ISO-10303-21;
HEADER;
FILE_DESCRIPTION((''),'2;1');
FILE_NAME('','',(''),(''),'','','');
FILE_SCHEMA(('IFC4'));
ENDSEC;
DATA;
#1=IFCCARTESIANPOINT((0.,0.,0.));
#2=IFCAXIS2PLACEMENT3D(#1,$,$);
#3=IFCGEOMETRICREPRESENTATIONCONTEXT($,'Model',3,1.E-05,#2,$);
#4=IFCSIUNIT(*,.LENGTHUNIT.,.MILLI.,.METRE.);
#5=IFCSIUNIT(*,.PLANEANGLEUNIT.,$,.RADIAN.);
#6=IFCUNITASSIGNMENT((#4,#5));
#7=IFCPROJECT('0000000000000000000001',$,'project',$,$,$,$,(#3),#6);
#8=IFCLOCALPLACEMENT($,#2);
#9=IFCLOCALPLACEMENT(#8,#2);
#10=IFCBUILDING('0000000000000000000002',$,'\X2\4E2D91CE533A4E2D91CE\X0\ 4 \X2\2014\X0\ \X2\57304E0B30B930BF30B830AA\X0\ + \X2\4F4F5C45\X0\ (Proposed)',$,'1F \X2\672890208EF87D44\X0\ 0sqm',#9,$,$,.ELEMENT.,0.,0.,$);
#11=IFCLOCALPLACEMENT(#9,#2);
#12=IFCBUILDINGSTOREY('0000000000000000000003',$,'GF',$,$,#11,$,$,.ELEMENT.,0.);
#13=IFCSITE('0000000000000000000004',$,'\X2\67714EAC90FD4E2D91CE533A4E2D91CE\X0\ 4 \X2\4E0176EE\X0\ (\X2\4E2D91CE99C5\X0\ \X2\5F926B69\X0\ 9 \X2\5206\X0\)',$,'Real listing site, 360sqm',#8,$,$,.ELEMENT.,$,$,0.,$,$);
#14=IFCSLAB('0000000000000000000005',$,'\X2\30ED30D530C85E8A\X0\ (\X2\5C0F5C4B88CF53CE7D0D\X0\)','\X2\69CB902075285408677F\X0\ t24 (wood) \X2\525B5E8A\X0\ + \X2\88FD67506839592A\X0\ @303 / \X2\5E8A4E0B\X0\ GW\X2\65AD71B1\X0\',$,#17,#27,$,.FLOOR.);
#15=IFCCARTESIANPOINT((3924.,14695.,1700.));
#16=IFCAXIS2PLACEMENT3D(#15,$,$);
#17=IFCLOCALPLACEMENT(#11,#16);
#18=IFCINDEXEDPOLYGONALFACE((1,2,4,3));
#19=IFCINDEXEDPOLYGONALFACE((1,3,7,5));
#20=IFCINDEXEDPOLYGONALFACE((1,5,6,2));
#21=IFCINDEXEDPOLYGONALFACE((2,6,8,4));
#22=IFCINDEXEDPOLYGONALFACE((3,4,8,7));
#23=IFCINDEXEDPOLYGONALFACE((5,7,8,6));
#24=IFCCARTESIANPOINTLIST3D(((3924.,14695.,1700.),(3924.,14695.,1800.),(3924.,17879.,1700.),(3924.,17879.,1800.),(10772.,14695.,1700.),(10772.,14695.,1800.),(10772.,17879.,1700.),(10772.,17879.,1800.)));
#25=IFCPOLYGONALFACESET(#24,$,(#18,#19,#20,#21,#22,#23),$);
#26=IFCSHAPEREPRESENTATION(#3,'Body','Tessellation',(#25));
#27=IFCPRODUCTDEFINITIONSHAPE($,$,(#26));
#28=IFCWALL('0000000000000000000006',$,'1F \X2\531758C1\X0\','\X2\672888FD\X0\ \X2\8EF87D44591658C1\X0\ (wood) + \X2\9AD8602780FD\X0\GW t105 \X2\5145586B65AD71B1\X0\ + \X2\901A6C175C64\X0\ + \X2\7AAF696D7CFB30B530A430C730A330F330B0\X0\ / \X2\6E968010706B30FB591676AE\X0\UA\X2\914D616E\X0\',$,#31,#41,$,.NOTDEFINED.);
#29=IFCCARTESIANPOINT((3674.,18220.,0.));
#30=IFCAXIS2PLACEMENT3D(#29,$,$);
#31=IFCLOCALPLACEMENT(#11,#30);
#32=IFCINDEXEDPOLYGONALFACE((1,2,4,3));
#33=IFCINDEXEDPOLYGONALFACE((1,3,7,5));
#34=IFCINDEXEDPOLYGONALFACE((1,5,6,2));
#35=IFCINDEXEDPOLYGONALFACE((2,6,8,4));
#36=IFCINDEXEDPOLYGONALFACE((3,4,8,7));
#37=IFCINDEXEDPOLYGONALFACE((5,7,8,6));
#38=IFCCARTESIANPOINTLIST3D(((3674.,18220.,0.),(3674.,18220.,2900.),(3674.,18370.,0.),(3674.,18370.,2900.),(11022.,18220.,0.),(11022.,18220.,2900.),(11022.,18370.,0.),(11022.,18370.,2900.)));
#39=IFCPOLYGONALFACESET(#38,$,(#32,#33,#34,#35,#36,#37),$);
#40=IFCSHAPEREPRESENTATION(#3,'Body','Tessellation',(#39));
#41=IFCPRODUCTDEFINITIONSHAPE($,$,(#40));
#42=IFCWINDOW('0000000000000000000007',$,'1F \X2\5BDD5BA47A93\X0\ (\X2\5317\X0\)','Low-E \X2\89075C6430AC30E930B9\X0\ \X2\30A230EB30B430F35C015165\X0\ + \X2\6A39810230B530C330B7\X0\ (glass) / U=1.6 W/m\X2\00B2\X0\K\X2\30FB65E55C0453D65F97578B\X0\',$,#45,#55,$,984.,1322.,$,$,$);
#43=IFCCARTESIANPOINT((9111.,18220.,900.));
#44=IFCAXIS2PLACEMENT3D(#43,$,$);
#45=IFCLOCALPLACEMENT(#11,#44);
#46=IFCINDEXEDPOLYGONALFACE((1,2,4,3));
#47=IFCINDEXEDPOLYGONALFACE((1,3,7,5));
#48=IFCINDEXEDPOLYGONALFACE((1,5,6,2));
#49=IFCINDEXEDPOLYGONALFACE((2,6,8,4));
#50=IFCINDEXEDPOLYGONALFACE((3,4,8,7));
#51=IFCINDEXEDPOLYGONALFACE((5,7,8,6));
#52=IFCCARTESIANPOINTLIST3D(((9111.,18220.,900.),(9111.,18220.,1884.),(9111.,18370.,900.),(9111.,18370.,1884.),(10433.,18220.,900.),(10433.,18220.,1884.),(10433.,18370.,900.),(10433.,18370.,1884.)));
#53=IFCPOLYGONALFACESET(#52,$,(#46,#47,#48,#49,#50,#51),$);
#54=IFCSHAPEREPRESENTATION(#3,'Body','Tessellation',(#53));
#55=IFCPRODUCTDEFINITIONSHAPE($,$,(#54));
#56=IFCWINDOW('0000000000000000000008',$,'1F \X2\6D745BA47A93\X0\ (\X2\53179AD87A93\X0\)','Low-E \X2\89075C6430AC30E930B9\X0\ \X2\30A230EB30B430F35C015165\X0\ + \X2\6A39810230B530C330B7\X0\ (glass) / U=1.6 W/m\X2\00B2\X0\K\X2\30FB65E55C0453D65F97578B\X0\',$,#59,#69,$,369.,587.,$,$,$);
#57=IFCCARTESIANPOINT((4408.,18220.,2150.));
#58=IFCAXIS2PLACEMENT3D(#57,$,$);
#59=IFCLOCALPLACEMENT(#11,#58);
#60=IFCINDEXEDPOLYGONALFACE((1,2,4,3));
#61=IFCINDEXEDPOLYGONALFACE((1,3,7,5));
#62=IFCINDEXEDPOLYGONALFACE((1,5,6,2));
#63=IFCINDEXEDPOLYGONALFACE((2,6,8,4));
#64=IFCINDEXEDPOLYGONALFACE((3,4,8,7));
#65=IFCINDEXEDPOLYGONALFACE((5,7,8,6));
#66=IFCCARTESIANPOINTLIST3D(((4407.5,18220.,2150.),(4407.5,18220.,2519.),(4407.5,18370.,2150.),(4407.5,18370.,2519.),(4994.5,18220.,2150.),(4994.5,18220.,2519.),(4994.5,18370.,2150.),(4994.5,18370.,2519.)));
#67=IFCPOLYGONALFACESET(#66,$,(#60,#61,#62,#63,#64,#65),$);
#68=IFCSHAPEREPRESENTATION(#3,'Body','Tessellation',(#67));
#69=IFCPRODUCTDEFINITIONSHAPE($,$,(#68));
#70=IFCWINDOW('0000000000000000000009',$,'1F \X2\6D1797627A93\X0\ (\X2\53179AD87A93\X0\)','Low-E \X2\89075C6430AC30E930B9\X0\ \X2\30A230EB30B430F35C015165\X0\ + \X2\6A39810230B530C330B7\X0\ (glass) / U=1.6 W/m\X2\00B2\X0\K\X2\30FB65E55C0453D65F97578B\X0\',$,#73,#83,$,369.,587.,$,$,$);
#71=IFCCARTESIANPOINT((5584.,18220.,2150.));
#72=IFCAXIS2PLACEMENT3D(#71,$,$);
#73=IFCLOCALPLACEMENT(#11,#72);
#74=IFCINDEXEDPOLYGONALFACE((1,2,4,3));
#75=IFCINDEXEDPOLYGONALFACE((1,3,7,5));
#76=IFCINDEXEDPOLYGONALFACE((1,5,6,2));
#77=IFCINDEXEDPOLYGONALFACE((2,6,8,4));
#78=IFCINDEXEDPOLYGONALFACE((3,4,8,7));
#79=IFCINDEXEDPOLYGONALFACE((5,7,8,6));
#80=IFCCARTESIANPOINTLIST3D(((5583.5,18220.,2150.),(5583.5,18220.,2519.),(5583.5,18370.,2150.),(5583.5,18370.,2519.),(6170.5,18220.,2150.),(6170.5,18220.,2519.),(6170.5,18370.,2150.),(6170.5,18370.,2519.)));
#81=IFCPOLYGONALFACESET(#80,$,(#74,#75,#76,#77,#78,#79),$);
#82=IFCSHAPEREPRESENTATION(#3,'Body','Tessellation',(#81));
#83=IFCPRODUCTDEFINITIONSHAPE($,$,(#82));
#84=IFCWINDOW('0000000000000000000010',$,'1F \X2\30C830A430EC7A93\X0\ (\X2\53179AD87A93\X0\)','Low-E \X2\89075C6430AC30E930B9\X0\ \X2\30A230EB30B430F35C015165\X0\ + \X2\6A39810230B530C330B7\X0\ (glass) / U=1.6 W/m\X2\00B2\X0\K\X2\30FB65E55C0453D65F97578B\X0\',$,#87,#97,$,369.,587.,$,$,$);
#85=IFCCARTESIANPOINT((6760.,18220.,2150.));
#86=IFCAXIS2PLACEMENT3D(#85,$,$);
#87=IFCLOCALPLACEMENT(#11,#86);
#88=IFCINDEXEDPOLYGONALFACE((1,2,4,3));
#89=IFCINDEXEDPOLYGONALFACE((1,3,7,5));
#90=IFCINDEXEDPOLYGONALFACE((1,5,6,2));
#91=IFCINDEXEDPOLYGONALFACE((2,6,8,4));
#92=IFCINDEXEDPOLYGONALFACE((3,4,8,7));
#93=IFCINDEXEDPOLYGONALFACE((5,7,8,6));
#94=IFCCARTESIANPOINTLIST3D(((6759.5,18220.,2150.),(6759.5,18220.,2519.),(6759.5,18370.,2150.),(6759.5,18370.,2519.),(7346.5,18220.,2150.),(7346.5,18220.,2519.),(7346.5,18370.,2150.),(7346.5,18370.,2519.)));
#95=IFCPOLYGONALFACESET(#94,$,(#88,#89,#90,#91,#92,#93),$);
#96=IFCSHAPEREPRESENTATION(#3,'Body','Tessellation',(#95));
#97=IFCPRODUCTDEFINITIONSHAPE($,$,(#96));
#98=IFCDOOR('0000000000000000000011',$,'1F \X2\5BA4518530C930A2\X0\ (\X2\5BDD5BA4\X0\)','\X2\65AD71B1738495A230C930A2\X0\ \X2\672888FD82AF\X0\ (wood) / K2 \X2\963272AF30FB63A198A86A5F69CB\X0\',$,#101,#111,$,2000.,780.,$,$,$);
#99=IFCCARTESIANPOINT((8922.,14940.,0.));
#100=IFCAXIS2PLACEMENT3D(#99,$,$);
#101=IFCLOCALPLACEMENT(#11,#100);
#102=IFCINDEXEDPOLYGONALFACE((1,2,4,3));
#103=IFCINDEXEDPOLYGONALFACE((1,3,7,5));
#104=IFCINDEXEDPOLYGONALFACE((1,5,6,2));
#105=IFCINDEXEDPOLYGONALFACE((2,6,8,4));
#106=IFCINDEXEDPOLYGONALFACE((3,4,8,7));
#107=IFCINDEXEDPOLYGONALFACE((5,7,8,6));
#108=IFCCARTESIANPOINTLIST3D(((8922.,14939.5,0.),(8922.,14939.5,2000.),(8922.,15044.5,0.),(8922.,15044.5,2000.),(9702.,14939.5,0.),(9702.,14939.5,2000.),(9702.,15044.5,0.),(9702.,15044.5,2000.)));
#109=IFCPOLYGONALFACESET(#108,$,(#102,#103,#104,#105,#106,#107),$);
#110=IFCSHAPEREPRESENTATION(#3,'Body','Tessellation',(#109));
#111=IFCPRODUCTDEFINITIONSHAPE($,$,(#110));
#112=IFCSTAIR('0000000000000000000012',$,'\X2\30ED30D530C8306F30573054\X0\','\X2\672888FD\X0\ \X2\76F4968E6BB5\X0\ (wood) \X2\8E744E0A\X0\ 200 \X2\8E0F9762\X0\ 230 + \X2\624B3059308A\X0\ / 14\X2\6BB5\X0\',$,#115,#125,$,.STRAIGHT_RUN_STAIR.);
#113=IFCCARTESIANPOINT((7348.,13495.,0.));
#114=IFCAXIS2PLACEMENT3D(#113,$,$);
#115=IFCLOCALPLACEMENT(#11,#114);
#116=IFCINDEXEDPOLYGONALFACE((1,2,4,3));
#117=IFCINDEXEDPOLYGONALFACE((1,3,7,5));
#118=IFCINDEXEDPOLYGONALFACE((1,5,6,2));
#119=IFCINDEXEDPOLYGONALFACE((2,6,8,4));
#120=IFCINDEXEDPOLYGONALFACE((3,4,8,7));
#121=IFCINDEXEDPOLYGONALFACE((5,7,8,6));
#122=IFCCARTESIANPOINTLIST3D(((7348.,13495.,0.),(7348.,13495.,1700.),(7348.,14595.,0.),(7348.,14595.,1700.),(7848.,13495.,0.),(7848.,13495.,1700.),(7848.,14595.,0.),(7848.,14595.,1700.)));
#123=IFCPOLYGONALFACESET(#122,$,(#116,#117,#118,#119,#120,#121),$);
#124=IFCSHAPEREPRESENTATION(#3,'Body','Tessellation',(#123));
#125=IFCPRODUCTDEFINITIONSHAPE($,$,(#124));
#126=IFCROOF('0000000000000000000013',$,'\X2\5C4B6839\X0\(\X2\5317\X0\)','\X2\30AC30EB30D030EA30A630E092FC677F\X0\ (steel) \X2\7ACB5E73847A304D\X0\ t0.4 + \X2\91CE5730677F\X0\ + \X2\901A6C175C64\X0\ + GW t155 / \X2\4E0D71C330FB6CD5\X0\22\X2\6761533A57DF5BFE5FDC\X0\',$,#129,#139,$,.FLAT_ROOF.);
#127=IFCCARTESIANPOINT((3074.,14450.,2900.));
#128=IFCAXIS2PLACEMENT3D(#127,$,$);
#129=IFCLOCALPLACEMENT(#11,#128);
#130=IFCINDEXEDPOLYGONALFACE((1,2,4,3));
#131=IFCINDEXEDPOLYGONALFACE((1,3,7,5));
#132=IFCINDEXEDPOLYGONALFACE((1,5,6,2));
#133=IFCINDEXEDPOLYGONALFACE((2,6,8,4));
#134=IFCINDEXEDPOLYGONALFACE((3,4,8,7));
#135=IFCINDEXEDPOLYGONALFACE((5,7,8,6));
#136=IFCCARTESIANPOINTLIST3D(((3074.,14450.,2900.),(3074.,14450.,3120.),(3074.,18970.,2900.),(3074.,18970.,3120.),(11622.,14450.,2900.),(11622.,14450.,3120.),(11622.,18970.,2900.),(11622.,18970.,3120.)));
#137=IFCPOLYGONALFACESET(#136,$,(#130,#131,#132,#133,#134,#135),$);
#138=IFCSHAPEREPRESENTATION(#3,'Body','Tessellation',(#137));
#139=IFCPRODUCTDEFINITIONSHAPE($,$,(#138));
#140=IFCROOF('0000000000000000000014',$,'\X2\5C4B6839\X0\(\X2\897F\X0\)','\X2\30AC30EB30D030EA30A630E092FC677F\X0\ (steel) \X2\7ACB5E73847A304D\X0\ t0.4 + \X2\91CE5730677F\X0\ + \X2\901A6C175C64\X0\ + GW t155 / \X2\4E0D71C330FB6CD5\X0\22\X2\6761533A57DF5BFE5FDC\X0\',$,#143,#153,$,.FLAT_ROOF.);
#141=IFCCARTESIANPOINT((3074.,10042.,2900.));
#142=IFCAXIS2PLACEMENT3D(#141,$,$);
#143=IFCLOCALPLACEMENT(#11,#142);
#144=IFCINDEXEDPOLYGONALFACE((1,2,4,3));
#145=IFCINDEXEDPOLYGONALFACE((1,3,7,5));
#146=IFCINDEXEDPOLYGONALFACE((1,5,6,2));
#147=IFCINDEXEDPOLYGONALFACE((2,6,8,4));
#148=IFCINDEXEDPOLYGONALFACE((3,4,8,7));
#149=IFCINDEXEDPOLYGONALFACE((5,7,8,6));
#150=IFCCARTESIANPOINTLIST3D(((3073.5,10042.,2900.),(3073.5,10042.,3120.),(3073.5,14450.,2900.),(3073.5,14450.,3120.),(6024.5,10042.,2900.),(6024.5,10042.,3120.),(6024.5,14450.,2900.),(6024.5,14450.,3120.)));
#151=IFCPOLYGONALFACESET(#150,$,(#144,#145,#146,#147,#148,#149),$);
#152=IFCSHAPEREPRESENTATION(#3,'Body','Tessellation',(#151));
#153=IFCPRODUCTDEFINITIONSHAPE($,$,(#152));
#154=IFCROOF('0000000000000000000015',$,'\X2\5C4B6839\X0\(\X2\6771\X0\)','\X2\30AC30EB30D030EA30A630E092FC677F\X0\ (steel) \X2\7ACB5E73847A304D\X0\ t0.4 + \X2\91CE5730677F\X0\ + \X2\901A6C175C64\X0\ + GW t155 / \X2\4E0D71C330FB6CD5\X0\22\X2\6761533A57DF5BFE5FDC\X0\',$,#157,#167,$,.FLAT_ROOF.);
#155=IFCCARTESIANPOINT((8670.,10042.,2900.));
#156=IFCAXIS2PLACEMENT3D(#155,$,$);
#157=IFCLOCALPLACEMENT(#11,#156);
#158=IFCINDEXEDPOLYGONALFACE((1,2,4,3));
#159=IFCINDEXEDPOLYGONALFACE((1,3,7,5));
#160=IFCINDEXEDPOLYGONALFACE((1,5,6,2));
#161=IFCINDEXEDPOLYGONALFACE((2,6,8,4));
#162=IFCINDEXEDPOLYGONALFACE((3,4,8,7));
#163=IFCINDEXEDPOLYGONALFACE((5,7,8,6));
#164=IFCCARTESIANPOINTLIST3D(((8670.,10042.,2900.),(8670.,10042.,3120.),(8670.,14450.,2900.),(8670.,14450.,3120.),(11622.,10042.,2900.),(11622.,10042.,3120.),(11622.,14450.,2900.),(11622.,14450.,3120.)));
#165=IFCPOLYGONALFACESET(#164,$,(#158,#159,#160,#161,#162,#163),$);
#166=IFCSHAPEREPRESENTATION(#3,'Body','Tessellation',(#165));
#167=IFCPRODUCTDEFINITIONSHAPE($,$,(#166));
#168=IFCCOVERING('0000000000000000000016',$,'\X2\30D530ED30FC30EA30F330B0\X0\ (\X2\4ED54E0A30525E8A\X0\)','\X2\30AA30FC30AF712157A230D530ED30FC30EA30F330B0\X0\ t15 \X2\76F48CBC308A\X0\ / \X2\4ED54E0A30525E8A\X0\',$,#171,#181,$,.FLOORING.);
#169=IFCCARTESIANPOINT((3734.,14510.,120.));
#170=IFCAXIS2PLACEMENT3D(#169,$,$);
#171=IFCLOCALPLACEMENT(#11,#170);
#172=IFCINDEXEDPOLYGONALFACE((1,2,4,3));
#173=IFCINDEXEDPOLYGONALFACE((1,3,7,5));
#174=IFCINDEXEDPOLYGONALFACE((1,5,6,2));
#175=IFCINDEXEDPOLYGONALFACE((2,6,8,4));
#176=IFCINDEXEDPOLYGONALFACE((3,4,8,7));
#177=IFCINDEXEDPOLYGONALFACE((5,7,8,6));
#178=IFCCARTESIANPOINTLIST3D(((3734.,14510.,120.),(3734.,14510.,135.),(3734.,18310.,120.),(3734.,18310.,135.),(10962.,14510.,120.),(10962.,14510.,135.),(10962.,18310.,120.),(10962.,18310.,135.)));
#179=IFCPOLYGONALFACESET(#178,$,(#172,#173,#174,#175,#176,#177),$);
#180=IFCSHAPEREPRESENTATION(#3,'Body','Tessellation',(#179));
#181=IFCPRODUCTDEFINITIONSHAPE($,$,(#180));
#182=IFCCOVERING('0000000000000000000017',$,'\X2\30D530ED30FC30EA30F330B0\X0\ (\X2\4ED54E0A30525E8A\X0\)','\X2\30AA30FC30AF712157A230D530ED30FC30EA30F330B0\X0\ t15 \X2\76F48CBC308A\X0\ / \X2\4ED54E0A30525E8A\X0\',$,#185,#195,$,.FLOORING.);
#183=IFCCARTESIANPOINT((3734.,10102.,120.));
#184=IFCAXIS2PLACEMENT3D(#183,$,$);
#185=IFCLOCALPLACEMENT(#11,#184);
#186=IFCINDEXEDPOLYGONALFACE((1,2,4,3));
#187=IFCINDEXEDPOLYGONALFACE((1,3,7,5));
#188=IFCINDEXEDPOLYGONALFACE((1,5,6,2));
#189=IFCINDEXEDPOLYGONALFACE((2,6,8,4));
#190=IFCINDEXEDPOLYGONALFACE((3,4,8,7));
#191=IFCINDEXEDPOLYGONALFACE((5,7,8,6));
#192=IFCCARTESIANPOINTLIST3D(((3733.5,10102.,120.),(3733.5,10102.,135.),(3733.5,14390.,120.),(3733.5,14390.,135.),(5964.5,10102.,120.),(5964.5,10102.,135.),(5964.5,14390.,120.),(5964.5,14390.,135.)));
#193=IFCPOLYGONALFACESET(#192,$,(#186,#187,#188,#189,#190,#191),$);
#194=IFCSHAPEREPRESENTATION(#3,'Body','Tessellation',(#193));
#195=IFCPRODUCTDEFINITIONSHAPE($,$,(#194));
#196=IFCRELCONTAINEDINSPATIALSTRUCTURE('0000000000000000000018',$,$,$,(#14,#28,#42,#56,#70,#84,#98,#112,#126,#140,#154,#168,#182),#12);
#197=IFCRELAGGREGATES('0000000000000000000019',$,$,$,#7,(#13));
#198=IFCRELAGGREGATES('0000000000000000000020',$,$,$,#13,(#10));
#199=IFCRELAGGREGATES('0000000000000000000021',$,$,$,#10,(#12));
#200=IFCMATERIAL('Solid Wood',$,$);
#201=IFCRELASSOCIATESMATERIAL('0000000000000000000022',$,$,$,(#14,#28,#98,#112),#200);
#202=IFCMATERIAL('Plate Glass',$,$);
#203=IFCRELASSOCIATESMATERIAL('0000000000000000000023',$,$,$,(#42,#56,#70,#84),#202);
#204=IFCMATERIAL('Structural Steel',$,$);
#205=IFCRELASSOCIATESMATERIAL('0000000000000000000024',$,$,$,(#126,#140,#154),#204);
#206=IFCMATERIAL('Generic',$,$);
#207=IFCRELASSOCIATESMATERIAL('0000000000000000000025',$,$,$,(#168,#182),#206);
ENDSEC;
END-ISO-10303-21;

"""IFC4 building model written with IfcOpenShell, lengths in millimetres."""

from ifc_helpers import new_model, si_unit, frame, frame_2d, origin, place, context, project, spatial, rectangle, extrude, material, element, fill, save


model = new_model("IFC4")

# Units and contexts
model_context = context("Model", 3, precision=1e-05, world=origin())
ifc_project = project(units=[si_unit("LENGTHUNIT", "METRE", prefix="MILLI"), si_unit("PLANEANGLEUNIT", "RADIAN")], contexts=[model_context])

# Site, building, storey
site_placement = place(None, origin())
site = spatial("IfcSite", under=ifc_project, at=site_placement, Name="東京都中野区中野 4 丁目 (中野駅 徒歩 9 分)", ObjectType="Real listing site, 360sqm", CompositionType="ELEMENT", RefElevation=0.0)
building_placement = place(site_placement, origin())
building = spatial("IfcBuilding", under=site, at=building_placement, Name="中野区中野 4 — 地下スタジオ + 住居 (Proposed)", ObjectType="1F 木造軸組 0sqm", CompositionType="ELEMENT", ElevationOfRefHeight=0.0, ElevationOfTerrain=0.0)
storey_placement = place(building_placement, origin())
storey = spatial("IfcBuildingStorey", under=building, at=storey_placement, Name="GF", CompositionType="ELEMENT", Elevation=0.0)

# Slab
ifc_material_1 = material(Name="Solid Wood")
slab_1_placement = place(storey_placement, frame((3924.0, 14695.0, 1700.0)))
element("IfcSlab", 1, at=slab_1_placement, inside=storey, material=ifc_material_1, Name="ロフト床 (小屋裏収納)", Description="構造用合板 t24 (wood) 剛床 + 製材根太 @303 / 床下 GW断熱", PredefinedType="FLOOR", context=model_context, shape_type="SweptSolid", body=[
    extrude(rectangle(XDim=6848.0, YDim=3184.0, at=frame_2d((3424.0, 1592.0))), frame((3924.0, 14695.0, 1700.0)), (0.0, 0.0, 1.0), 100.0),
])

# Wall, openings, windows
wall_1_placement = place(storey_placement, frame((3674.0, 18220.0, 0.0)))
wall_1 = element("IfcWall", 2, at=wall_1_placement, inside=storey, material=ifc_material_1, Name="1F 北壁", Description="木製 軸組外壁 (wood) + 高性能GW t105 充填断熱 + 通気層 + 窯業系サイディング / 準耐火・外皮UA配慮", PredefinedType="NOTDEFINED", context=model_context, shape_type="SweptSolid", body=[
    extrude(rectangle(XDim=7348.0, YDim=150.0, at=frame_2d((3674.0, 75.0))), frame((3674.0, 18220.0, 0.0)), (0.0, 0.0, 1.0), 2900.0),
])
opening_1_placement = place(storey_placement, frame((9111.0, 18220.0, 900.0)))
opening_1 = element("IfcOpeningElement", 3, at=opening_1_placement, cuts=wall_1, PredefinedType="NOTDEFINED", context=model_context, shape_type="SweptSolid", body=[
    extrude(rectangle(XDim=1322.0, YDim=150.0, at=frame_2d((661.0, 75.0))), frame((9111.0, 18220.0, 900.0)), (0.0, 0.0, 1.0), 984.0),
])
opening_2_placement = place(storey_placement, frame((4408.0, 18220.0, 2150.0)))
opening_2 = element("IfcOpeningElement", 4, at=opening_2_placement, cuts=wall_1, PredefinedType="NOTDEFINED", context=model_context, shape_type="SweptSolid", body=[
    extrude(rectangle(XDim=587.0, YDim=150.0, at=frame_2d((293.0, 75.0))), frame((4408.0, 18220.0, 2150.0)), (0.0, 0.0, 1.0), 369.0),
])
opening_3_placement = place(storey_placement, frame((5584.0, 18220.0, 2150.0)))
opening_3 = element("IfcOpeningElement", 5, at=opening_3_placement, cuts=wall_1, PredefinedType="NOTDEFINED", context=model_context, shape_type="SweptSolid", body=[
    extrude(rectangle(XDim=587.0, YDim=150.0, at=frame_2d((293.0, 75.0))), frame((5584.0, 18220.0, 2150.0)), (0.0, 0.0, 1.0), 369.0),
])
opening_4_placement = place(storey_placement, frame((6760.0, 18220.0, 2150.0)))
opening_4 = element("IfcOpeningElement", 6, at=opening_4_placement, cuts=wall_1, PredefinedType="NOTDEFINED", context=model_context, shape_type="SweptSolid", body=[
    extrude(rectangle(XDim=587.0, YDim=150.0, at=frame_2d((293.0, 75.0))), frame((6760.0, 18220.0, 2150.0)), (0.0, 0.0, 1.0), 369.0),
])
ifc_material_2 = material(Name="Plate Glass")
window_1_placement = place(storey_placement, frame((9111.0, 18220.0, 900.0)))
window_1 = element("IfcWindow", 7, at=window_1_placement, inside=storey, material=ifc_material_2, Name="1F 寝室窓 (北)", Description="Low-E 複層ガラス アルゴン封入 + 樹脂サッシ (glass) / U=1.6 W/m²K・日射取得型", OverallHeight=984.0, OverallWidth=1322.0, context=model_context, shape_type="SweptSolid", body=[
    extrude(rectangle(XDim=1322.0, YDim=150.0, at=frame_2d((661.0, 75.0))), frame((9111.0, 18220.0, 900.0)), (0.0, 0.0, 1.0), 984.0),
])
fill(opening_1, window_1)
window_2_placement = place(storey_placement, frame((4408.0, 18220.0, 2150.0)))
window_2 = element("IfcWindow", 8, at=window_2_placement, inside=storey, material=ifc_material_2, Name="1F 浴室窓 (北高窓)", Description="Low-E 複層ガラス アルゴン封入 + 樹脂サッシ (glass) / U=1.6 W/m²K・日射取得型", OverallHeight=369.0, OverallWidth=587.0, context=model_context, shape_type="SweptSolid", body=[
    extrude(rectangle(XDim=587.0, YDim=150.0, at=frame_2d((293.0, 75.0))), frame((4408.0, 18220.0, 2150.0)), (0.0, 0.0, 1.0), 369.0),
])
fill(opening_2, window_2)
window_3_placement = place(storey_placement, frame((5584.0, 18220.0, 2150.0)))
window_3 = element("IfcWindow", 9, at=window_3_placement, inside=storey, material=ifc_material_2, Name="1F 洗面窓 (北高窓)", Description="Low-E 複層ガラス アルゴン封入 + 樹脂サッシ (glass) / U=1.6 W/m²K・日射取得型", OverallHeight=369.0, OverallWidth=587.0, context=model_context, shape_type="SweptSolid", body=[
    extrude(rectangle(XDim=587.0, YDim=150.0, at=frame_2d((293.0, 75.0))), frame((5584.0, 18220.0, 2150.0)), (0.0, 0.0, 1.0), 369.0),
])
fill(opening_3, window_3)
window_4_placement = place(storey_placement, frame((6760.0, 18220.0, 2150.0)))
window_4 = element("IfcWindow", 10, at=window_4_placement, inside=storey, material=ifc_material_2, Name="1F トイレ窓 (北高窓)", Description="Low-E 複層ガラス アルゴン封入 + 樹脂サッシ (glass) / U=1.6 W/m²K・日射取得型", OverallHeight=369.0, OverallWidth=587.0, context=model_context, shape_type="SweptSolid", body=[
    extrude(rectangle(XDim=587.0, YDim=150.0, at=frame_2d((293.0, 75.0))), frame((6760.0, 18220.0, 2150.0)), (0.0, 0.0, 1.0), 369.0),
])
fill(opening_4, window_4)

# Door
door_1_placement = place(storey_placement, frame((8922.0, 14940.0, 0.0)))
element("IfcDoor", 11, at=door_1_placement, inside=storey, material=ifc_material_1, Name="1F 室内ドア (寝室)", Description="断熱玄関ドア 木製芯 (wood) / K2 防犯・採風機構", OverallHeight=2000.0, OverallWidth=780.0, context=model_context, shape_type="SweptSolid", body=[
    extrude(rectangle(XDim=780.0, YDim=105.0, at=frame_2d((390.0, 52.0))), frame((8922.0, 14940.0, 0.0)), (0.0, 0.0, 1.0), 2000.0),
])

# Stair
stair_placement = place(storey_placement, frame((7348.0, 13495.0, 0.0)))
element("IfcStair", 12, at=stair_placement, inside=storey, material=ifc_material_1, Name="ロフトはしご", Description="木製 直階段 (wood) 蹴上 200 踏面 230 + 手すり / 14段", PredefinedType="STRAIGHT_RUN_STAIR", context=model_context, shape_type="SweptSolid", body=[
    extrude(rectangle(XDim=500.0, YDim=1100.0, at=frame_2d((250.0, 550.0))), frame((7348.0, 13495.0, 0.0)), (0.0, 0.0, 1.0), 1700.0),
])

# Roofs
ifc_material_3 = material(Name="Structural Steel")
roof_1_placement = place(storey_placement, frame((3074.0, 14450.0, 2900.0)))
element("IfcRoof", 13, at=roof_1_placement, inside=storey, material=ifc_material_3, Name="屋根(北)", Description="ガルバリウム鋼板 (steel) 立平葺き t0.4 + 野地板 + 通気層 + GW t155 / 不燃・法22条区域対応", PredefinedType="FLAT_ROOF", context=model_context, shape_type="SweptSolid", body=[
    extrude(rectangle(XDim=8548.0, YDim=4520.0, at=frame_2d((4274.0, 2260.0))), frame((3074.0, 14450.0, 2900.0)), (0.0, 0.0, 1.0), 220.0),
])
roof_2_placement = place(storey_placement, frame((3074.0, 10042.0, 2900.0)))
element("IfcRoof", 14, at=roof_2_placement, inside=storey, material=ifc_material_3, Name="屋根(西)", Description="ガルバリウム鋼板 (steel) 立平葺き t0.4 + 野地板 + 通気層 + GW t155 / 不燃・法22条区域対応", PredefinedType="FLAT_ROOF", context=model_context, shape_type="SweptSolid", body=[
    extrude(rectangle(XDim=2951.0, YDim=4408.0, at=frame_2d((1475.0, 2204.0))), frame((3074.0, 10042.0, 2900.0)), (0.0, 0.0, 1.0), 220.0),
])
roof_3_placement = place(storey_placement, frame((8670.0, 10042.0, 2900.0)))
element("IfcRoof", 15, at=roof_3_placement, inside=storey, material=ifc_material_3, Name="屋根(東)", Description="ガルバリウム鋼板 (steel) 立平葺き t0.4 + 野地板 + 通気層 + GW t155 / 不燃・法22条区域対応", PredefinedType="FLAT_ROOF", context=model_context, shape_type="SweptSolid", body=[
    extrude(rectangle(XDim=2952.0, YDim=4408.0, at=frame_2d((1476.0, 2204.0))), frame((8670.0, 10042.0, 2900.0)), (0.0, 0.0, 1.0), 220.0),
])

# Coverings
ifc_material_4 = material(Name="Generic")
covering_1_placement = place(storey_placement, frame((3734.0, 14510.0, 120.0)))
element("IfcCovering", 16, at=covering_1_placement, inside=storey, material=ifc_material_4, Name="フローリング (仕上げ床)", Description="オーク無垢フローリング t15 直貼り / 仕上げ床", PredefinedType="FLOORING", context=model_context, shape_type="SweptSolid", body=[
    extrude(rectangle(XDim=7228.0, YDim=3800.0, at=frame_2d((3614.0, 1900.0))), frame((3734.0, 14510.0, 120.0)), (0.0, 0.0, 1.0), 15.0),
])
covering_2_placement = place(storey_placement, frame((3734.0, 10102.0, 120.0)))
element("IfcCovering", 17, at=covering_2_placement, inside=storey, material=ifc_material_4, Name="フローリング (仕上げ床)", Description="オーク無垢フローリング t15 直貼り / 仕上げ床", PredefinedType="FLOORING", context=model_context, shape_type="SweptSolid", body=[
    extrude(rectangle(XDim=2231.0, YDim=4288.0, at=frame_2d((1115.0, 2144.0))), frame((3734.0, 10102.0, 120.0)), (0.0, 0.0, 1.0), 15.0),
])

save(model, "model.ifc")
